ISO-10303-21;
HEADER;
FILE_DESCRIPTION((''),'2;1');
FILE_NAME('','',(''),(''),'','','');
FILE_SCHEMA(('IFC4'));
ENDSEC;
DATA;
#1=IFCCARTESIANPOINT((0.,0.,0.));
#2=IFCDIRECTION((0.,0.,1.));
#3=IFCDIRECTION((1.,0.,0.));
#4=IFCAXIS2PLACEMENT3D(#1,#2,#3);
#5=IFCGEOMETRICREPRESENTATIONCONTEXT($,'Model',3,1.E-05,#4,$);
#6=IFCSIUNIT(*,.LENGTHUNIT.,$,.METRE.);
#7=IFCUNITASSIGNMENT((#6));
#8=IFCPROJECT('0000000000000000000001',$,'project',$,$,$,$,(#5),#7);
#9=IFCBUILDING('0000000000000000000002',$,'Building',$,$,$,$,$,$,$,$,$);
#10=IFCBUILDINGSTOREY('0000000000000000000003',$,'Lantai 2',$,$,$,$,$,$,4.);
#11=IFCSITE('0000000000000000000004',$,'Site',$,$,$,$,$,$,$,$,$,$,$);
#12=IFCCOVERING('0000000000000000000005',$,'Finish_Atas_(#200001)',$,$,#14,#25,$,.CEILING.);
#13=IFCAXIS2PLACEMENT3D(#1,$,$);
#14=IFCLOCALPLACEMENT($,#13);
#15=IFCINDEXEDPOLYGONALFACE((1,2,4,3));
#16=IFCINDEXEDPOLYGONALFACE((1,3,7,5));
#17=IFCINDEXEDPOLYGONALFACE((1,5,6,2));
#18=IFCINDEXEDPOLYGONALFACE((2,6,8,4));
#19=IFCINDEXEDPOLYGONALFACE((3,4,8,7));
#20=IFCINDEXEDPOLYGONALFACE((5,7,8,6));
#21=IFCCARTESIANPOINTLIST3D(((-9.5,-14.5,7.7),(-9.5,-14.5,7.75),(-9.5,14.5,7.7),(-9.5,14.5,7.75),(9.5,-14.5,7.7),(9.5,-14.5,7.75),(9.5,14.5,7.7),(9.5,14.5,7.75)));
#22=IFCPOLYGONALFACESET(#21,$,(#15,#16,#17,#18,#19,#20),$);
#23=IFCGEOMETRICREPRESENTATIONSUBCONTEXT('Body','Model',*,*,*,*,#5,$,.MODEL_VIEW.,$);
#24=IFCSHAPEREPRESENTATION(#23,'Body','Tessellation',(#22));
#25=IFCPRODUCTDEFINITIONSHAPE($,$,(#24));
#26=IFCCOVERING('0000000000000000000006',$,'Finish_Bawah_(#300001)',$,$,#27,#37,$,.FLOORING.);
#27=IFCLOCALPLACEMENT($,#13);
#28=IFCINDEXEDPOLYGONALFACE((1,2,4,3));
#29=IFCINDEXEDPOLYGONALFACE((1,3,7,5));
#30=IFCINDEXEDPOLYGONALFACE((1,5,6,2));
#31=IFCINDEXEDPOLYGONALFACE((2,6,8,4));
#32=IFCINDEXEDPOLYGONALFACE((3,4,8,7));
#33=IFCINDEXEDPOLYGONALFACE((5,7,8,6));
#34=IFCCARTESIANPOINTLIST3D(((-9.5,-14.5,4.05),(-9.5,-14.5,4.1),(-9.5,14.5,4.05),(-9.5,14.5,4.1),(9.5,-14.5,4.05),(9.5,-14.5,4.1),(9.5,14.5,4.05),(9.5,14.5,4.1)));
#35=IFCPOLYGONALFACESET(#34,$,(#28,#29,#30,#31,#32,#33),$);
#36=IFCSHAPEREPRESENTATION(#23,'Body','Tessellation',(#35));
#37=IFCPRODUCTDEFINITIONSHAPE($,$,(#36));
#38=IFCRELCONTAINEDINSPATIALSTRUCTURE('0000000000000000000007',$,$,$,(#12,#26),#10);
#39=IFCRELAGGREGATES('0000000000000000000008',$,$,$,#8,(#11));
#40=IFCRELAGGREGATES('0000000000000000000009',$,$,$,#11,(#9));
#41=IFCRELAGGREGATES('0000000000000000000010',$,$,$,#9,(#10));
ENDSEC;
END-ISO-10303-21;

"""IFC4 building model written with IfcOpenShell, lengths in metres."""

from ifc_helpers import new_model, si_unit, frame, origin_with_axes, place, context, subcontext, project, spatial, polyline, outline, extrude, element, save


model = new_model("IFC4")

# Units and contexts
model_context = context("Model", 3, precision=1e-05, world=origin_with_axes())
body_context = subcontext(model_context, "Body", "Model", "MODEL_VIEW")
ifc_project = project(units=[si_unit("LENGTHUNIT", "METRE")], contexts=[model_context])

# Site, building, storey
site = spatial("IfcSite", under=ifc_project, Name="Site")
building = spatial("IfcBuilding", under=site, Name="Building")
storey = spatial("IfcBuildingStorey", under=building, Name="Lantai 2", Elevation=4.0)

# Coverings
covering_1_placement = place(None, origin_with_axes())
element("IfcCovering", 1, at=covering_1_placement, inside=storey, Name="Finish_Atas_(#200001)", PredefinedType="CEILING", context=body_context, shape_type="SweptSolid", body=[
    extrude(outline(polyline([(-9.5, -14.5), (9.5, -14.5), (9.5, 14.5), (-9.5, 14.5), (-9.5, -14.5)])), frame((0.0, 0.0, 7.7), z_axis=(0.0, 0.0, 1.0), x_axis=(1.0, 0.0, 0.0)), (0.0, 0.0, 1.0), 0.05),
])
covering_2_placement = place(None, origin_with_axes())
element("IfcCovering", 2, at=covering_2_placement, inside=storey, Name="Finish_Bawah_(#300001)", PredefinedType="FLOORING", context=body_context, shape_type="SweptSolid", body=[
    extrude(outline(polyline([(-9.5, -14.5), (9.5, -14.5), (9.5, 14.5), (-9.5, 14.5), (-9.5, -14.5)])), frame((0.0, 0.0, 4.05), z_axis=(0.0, 0.0, 1.0), x_axis=(1.0, 0.0, 0.0)), (0.0, 0.0, 1.0), 0.05),
])

save(model, "model.ifc")
